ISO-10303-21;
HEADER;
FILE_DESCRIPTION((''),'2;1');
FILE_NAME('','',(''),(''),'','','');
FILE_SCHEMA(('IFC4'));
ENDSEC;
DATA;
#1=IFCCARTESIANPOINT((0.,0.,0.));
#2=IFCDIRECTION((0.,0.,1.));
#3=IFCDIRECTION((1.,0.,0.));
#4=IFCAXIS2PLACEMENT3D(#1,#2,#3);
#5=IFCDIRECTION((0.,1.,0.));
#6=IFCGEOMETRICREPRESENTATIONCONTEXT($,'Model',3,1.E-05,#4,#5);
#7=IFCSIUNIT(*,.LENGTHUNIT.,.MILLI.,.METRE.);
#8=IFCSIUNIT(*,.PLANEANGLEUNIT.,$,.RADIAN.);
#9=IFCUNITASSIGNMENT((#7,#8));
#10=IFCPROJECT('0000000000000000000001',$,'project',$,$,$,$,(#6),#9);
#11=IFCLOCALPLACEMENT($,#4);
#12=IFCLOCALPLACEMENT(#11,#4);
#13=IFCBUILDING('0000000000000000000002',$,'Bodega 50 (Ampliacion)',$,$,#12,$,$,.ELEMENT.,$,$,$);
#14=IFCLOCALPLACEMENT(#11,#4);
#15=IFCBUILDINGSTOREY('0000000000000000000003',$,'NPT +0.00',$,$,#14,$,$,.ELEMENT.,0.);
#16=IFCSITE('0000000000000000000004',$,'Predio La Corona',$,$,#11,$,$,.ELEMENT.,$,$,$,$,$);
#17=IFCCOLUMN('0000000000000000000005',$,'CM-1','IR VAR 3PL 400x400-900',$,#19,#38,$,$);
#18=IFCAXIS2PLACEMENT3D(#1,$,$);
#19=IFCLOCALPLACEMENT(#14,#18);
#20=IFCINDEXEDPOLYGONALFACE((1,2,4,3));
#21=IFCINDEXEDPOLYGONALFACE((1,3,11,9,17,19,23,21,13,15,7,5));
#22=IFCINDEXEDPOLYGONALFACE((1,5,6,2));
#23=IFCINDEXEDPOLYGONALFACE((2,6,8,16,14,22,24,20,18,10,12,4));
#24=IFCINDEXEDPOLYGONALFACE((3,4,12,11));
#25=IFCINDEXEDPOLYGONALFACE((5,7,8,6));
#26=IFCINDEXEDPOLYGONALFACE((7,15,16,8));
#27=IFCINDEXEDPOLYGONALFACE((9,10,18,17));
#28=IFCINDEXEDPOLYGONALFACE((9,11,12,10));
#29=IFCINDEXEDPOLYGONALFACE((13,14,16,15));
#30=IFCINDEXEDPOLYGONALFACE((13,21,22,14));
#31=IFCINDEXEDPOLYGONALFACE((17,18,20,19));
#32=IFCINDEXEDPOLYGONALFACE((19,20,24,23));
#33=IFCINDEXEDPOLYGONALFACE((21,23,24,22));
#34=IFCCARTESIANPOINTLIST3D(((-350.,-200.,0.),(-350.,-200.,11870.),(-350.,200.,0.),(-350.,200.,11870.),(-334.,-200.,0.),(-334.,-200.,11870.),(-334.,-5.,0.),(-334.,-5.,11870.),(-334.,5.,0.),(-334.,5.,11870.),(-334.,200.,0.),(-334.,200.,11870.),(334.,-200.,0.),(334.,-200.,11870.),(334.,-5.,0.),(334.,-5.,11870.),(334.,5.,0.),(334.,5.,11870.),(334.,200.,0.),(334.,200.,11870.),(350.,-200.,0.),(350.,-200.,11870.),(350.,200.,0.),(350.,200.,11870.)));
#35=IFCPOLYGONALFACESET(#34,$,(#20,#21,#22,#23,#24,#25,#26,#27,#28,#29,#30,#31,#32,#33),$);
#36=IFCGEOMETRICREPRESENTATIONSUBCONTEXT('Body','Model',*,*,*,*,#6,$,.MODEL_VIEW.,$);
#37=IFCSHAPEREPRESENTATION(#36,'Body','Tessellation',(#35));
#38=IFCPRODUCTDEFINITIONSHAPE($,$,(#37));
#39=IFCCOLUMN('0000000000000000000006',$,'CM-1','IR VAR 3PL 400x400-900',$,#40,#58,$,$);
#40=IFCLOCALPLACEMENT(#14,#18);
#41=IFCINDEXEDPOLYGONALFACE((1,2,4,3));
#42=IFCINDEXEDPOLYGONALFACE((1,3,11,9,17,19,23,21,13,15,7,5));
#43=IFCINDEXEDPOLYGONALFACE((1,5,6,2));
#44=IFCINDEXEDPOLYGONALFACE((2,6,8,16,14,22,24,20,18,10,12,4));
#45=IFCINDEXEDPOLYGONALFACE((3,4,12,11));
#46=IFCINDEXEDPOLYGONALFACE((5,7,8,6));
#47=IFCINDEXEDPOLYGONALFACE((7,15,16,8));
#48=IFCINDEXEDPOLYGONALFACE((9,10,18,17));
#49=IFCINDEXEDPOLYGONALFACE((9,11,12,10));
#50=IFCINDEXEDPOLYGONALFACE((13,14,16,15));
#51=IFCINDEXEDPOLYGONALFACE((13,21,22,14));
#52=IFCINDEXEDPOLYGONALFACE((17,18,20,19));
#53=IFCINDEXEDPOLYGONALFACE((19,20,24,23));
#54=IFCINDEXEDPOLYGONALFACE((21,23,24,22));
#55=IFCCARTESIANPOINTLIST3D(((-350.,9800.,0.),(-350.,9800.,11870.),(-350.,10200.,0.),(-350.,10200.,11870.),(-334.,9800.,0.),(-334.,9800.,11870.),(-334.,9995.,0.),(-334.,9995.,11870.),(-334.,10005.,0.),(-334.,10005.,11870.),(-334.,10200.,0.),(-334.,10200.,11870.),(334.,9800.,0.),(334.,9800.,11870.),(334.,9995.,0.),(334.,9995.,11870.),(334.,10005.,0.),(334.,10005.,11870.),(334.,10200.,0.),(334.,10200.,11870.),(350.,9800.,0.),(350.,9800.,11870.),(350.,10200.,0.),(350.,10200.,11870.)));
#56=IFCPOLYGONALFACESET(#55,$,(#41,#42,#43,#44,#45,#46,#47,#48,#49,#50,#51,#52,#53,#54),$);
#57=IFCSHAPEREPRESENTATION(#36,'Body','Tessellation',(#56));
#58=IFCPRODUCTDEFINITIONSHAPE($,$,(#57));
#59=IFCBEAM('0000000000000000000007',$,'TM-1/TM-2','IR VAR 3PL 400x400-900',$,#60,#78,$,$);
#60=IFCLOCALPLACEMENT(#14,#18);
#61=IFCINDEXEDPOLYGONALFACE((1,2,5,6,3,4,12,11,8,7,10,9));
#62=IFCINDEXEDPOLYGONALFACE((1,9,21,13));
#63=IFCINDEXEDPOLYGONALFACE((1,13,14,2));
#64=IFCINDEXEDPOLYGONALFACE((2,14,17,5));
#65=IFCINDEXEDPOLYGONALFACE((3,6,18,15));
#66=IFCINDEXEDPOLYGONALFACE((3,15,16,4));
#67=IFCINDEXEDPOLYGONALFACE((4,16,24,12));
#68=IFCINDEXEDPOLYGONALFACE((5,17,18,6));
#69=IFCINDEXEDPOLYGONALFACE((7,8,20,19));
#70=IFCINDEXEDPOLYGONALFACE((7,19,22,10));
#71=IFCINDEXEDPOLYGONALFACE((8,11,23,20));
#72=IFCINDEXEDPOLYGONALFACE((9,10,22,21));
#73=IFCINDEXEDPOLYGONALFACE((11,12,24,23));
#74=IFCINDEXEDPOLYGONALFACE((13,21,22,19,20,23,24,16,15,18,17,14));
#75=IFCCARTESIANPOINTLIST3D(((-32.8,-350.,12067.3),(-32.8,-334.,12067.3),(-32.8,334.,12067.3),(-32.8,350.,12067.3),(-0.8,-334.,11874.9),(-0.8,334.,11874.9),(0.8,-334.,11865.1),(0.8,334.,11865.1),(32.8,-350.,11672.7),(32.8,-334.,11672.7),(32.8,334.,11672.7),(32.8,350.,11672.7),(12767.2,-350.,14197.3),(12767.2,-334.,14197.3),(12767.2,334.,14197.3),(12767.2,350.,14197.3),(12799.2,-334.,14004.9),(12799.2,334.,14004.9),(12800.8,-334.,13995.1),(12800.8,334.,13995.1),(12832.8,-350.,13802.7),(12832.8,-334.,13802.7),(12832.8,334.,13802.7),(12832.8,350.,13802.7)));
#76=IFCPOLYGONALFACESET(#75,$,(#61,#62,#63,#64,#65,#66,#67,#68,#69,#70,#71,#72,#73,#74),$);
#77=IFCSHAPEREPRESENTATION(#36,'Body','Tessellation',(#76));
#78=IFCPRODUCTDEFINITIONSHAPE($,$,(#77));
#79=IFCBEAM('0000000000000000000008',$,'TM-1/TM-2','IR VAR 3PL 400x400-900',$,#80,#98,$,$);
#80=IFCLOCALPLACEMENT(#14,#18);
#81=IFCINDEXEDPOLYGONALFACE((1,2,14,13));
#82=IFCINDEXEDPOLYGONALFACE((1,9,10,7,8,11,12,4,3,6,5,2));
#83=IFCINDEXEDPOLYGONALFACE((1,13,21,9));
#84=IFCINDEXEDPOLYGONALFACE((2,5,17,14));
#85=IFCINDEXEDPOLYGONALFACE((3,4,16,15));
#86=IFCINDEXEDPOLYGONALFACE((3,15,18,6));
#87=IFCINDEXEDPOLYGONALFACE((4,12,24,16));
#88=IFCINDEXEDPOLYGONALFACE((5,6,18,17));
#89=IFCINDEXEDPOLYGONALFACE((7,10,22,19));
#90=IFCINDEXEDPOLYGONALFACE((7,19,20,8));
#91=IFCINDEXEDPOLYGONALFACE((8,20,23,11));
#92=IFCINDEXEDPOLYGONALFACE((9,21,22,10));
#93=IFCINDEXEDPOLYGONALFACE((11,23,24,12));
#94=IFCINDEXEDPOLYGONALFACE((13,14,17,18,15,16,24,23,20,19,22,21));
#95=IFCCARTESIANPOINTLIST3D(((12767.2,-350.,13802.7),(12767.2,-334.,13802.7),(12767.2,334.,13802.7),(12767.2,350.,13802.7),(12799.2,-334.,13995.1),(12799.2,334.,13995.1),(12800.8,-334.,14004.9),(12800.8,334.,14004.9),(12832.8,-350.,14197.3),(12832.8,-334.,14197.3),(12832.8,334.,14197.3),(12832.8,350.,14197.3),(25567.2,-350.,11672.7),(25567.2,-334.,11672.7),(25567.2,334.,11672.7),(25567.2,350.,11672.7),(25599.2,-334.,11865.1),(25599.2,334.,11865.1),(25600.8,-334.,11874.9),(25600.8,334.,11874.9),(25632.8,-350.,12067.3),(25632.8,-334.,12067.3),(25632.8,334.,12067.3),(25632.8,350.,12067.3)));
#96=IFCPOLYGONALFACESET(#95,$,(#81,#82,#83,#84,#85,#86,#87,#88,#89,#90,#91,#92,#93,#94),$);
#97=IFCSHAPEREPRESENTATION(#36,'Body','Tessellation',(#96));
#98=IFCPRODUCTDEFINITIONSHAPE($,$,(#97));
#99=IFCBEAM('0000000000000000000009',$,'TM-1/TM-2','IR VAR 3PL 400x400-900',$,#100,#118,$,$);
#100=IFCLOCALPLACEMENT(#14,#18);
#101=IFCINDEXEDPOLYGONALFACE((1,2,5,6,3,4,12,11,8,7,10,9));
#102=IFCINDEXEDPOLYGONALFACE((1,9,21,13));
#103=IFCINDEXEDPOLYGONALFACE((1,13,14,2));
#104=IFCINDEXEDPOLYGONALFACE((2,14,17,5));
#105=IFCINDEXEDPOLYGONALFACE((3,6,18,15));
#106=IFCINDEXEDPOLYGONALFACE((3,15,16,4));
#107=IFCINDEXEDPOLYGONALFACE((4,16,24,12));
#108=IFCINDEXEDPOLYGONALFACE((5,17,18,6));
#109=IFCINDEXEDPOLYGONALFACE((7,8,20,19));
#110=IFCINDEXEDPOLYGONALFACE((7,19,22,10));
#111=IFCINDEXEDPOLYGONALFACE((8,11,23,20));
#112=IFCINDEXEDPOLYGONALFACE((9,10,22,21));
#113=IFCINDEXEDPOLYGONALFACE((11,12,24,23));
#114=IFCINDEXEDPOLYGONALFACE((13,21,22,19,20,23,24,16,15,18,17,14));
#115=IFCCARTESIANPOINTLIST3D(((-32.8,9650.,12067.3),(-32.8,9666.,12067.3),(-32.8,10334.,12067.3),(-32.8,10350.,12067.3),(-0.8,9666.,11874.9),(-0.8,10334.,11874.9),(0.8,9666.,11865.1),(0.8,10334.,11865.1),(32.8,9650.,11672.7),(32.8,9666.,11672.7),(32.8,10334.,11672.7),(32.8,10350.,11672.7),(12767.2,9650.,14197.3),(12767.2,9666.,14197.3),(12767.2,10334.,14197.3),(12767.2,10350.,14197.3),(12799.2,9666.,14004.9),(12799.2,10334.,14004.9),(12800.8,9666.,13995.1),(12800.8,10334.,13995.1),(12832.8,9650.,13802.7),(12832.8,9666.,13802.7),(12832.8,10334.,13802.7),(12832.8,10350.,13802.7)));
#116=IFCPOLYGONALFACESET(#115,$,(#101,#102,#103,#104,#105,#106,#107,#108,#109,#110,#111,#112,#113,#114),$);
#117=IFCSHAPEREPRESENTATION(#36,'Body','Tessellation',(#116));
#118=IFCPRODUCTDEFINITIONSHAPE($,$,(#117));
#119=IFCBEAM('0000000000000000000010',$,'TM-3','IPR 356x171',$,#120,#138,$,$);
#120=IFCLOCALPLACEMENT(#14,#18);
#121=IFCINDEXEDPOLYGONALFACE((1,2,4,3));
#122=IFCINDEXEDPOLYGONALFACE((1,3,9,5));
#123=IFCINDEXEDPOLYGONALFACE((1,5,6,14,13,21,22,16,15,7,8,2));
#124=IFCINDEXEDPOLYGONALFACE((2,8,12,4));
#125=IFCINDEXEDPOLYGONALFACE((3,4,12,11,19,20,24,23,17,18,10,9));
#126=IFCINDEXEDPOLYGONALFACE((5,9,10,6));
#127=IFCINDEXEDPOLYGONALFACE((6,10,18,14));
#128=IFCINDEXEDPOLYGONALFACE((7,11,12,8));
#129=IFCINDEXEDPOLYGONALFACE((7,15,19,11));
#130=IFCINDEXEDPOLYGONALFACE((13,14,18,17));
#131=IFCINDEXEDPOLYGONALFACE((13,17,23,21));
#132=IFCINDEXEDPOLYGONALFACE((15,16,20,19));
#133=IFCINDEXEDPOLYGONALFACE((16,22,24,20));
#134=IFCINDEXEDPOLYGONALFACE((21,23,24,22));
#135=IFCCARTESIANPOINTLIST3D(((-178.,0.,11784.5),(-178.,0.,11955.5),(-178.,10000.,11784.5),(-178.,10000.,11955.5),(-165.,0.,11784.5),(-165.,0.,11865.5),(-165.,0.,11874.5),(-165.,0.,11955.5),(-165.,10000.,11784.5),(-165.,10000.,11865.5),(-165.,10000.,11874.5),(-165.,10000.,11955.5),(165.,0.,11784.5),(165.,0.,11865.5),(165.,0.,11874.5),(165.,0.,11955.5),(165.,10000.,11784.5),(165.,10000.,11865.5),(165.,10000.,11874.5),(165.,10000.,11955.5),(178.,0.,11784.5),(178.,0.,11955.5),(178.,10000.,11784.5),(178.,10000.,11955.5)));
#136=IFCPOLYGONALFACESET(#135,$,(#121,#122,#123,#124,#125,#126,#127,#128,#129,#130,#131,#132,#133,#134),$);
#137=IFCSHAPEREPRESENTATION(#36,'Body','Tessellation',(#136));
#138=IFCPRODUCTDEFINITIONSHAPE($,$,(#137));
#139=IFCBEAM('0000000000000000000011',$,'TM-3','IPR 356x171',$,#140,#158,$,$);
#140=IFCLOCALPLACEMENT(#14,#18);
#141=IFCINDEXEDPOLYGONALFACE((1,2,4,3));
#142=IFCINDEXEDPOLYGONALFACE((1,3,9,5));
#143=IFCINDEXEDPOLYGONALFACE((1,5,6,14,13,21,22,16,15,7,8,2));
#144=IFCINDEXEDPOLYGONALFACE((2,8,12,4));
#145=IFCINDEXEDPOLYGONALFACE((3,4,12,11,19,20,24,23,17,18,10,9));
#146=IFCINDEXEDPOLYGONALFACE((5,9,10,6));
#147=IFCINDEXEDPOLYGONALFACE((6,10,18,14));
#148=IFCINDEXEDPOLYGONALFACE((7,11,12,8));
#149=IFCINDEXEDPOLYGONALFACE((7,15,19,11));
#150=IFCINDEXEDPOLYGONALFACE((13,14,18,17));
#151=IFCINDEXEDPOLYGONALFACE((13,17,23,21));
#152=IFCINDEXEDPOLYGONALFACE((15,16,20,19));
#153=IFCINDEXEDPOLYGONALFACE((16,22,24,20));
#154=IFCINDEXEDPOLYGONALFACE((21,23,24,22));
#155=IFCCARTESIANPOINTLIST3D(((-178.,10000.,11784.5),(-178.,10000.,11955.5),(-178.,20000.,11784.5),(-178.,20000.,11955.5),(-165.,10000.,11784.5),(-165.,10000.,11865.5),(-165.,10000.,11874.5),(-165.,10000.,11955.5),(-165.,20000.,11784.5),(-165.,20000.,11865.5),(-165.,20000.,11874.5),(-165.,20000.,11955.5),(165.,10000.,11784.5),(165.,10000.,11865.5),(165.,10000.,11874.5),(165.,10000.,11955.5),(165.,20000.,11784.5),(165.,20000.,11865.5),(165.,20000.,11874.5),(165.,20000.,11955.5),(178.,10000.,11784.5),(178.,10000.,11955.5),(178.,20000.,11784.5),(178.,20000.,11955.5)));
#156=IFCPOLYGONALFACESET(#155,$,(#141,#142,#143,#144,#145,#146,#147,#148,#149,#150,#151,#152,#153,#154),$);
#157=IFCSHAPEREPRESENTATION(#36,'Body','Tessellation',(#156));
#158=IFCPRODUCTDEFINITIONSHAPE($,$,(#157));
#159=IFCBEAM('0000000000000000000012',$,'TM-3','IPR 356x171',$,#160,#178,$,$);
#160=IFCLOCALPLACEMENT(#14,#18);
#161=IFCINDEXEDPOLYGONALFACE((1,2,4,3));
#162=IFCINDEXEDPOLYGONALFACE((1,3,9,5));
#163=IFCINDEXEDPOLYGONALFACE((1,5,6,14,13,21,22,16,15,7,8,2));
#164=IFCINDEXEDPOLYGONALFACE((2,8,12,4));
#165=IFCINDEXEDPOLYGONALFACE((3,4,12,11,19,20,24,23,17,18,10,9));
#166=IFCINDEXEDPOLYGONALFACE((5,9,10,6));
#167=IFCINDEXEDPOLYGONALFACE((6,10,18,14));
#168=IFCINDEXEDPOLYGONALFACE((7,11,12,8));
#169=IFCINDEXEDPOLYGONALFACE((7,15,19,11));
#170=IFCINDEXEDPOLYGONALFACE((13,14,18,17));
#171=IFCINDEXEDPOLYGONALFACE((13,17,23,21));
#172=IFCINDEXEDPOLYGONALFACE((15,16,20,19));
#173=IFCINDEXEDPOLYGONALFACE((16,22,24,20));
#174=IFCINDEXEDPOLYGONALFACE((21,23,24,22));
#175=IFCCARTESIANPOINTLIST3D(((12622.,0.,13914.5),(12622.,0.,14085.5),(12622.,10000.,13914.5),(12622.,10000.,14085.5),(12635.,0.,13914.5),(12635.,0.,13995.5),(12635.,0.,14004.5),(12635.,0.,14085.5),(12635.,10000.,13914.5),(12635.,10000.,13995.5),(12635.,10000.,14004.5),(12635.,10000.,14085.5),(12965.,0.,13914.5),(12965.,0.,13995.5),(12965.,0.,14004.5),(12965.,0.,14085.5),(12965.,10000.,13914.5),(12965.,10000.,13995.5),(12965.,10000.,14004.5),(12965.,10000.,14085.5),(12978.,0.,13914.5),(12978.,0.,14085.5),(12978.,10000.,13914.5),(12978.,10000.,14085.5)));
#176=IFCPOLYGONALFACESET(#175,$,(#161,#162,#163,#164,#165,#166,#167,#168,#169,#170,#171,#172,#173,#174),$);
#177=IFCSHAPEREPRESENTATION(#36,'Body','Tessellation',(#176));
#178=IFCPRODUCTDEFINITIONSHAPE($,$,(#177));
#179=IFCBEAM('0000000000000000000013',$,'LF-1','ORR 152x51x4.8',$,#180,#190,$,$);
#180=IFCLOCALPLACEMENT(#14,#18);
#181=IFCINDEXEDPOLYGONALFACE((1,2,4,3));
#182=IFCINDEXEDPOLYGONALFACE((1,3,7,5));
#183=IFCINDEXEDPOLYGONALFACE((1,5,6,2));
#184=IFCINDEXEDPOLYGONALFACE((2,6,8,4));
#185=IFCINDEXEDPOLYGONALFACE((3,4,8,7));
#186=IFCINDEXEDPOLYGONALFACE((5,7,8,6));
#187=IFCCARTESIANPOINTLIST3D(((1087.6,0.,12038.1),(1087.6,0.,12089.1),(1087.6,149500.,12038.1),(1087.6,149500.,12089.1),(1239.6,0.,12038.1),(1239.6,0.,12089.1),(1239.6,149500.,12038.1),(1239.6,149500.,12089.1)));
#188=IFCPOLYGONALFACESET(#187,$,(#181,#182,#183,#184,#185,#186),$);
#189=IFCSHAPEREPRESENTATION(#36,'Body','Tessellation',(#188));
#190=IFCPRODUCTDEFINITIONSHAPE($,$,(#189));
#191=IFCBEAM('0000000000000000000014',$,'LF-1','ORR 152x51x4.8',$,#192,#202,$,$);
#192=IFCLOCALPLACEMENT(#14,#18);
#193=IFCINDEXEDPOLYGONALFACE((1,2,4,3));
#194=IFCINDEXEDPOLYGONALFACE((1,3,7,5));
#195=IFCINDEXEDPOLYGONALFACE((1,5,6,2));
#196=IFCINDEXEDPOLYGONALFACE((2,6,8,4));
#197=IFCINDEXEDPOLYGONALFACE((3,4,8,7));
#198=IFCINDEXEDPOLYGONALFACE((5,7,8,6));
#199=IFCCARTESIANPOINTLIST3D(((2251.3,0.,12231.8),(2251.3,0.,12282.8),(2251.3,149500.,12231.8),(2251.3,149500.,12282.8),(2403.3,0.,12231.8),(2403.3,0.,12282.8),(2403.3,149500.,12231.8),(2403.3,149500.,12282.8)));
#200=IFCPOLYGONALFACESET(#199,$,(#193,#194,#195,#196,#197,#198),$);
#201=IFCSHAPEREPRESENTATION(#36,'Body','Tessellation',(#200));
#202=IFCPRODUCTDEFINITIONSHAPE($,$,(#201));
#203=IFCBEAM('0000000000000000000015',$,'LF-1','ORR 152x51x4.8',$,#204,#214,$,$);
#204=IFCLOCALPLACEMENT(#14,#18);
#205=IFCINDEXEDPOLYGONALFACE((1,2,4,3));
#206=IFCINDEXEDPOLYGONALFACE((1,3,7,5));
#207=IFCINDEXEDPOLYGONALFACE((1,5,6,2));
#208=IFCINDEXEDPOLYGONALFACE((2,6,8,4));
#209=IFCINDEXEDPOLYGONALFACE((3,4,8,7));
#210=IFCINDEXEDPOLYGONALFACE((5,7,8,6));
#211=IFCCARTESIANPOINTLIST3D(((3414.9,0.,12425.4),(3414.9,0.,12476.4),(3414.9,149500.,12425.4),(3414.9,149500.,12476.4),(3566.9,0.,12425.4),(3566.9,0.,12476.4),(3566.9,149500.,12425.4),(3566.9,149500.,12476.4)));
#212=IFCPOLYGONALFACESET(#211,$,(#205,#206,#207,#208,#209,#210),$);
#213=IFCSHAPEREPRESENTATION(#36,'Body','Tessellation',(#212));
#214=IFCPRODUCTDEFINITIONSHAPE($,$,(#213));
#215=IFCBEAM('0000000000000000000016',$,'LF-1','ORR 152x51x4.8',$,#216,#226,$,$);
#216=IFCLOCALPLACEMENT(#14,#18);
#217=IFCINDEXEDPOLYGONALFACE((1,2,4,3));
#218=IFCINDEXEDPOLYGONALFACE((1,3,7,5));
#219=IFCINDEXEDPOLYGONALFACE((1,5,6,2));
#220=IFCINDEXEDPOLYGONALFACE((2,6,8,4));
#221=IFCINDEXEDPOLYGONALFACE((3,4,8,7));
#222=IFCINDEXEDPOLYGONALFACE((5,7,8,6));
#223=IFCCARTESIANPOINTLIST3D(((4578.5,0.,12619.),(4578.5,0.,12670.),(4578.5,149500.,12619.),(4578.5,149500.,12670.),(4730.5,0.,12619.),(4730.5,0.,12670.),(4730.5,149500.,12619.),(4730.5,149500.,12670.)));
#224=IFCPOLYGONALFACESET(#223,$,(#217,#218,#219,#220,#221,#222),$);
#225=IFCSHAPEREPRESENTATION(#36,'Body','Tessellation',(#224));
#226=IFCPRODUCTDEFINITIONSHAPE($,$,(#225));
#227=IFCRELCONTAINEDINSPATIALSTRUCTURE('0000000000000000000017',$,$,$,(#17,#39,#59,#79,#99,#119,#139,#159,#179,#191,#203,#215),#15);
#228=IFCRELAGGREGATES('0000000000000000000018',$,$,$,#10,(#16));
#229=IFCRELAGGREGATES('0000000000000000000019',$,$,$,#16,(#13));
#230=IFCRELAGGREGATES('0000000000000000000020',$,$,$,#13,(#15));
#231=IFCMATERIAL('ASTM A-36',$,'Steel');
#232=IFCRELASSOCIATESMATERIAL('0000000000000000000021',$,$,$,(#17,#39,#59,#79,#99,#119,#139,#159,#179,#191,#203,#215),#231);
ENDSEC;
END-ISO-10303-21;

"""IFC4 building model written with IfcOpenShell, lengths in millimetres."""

from ifc_helpers import new_model, si_unit, direction, frame, origin_with_axes, origin_2d, place, context, subcontext, project, spatial, rectangle, i_section, extrude, material, element, save


model = new_model("IFC4")

# Units and contexts
model_context = context("Model", 3, precision=1e-05, world=origin_with_axes(), true_north=direction((0.0, 1.0, 0.0)))
body_context = subcontext(model_context, "Body", "Model", "MODEL_VIEW")
ifc_project = project(units=[si_unit("LENGTHUNIT", "METRE", prefix="MILLI"), si_unit("PLANEANGLEUNIT", "RADIAN")], contexts=[model_context])

# Site, building, storey
site_placement = place(None, origin_with_axes())
site = spatial("IfcSite", under=ifc_project, at=site_placement, Name="Predio La Corona", CompositionType="ELEMENT")
building_placement = place(site_placement, origin_with_axes())
building = spatial("IfcBuilding", under=site, at=building_placement, Name="Bodega 50 (Ampliacion)", CompositionType="ELEMENT")
storey_placement = place(site_placement, origin_with_axes())
storey = spatial("IfcBuildingStorey", under=building, at=storey_placement, Name="NPT +0.00", CompositionType="ELEMENT", Elevation=0.0)

# Columns
ifc_material = material(Name="ASTM A-36", Category="Steel")
for number, where, z_axis, x_axis, name in (
    (1, (0.0, 0.0, 0.0), (0.0, 0.0, 1.0), (0.0, -1.0, 0.0), "CM-1"),
    (2, (0.0, 10000.0, 0.0), (0.0, 0.0, 1.0), (0.0, -1.0, 0.0), "CM-1"),
):
    element("IfcColumn", number, at=place(storey_placement, frame(where, z_axis=z_axis, x_axis=x_axis)), inside=storey, material=ifc_material, Name=name, Description="IR VAR 3PL 400x400-900", context=body_context, shape_type="SweptSolid", body=[
        extrude(i_section(OverallWidth=400.0, OverallDepth=700.0, WebThickness=10.0, FlangeThickness=16.0, at=origin_2d()), origin_with_axes(), (0.0, 0.0, 1.0), 11870.0),
    ])

# Beams
for number, where, z_axis, x_axis, name in (
    (3, (0.0, 0.0, 11870.0), (0.986436, 0.0, 0.164149), (0.164149, 0.0, -0.986436), "TM-1/TM-2"),
    (4, (12800.0, 0.0, 14000.0), (0.986436, 0.0, -0.164149), (-0.164149, 0.0, -0.986436), "TM-1/TM-2"),
    (5, (0.0, 10000.0, 11870.0), (0.986436, 0.0, 0.164149), (0.164149, 0.0, -0.986436), "TM-1/TM-2"),
):
    element("IfcBeam", number, at=place(storey_placement, frame(where, z_axis=z_axis, x_axis=x_axis)), inside=storey, material=ifc_material, Name=name, Description="IR VAR 3PL 400x400-900", context=body_context, shape_type="SweptSolid", body=[
        extrude(i_section(OverallWidth=400.0, OverallDepth=700.0, WebThickness=10.0, FlangeThickness=16.0, at=origin_2d()), origin_with_axes(), (0.0, 0.0, 1.0), 12976.0),
    ])
for number, where, z_axis, x_axis, name in (
    (6, (0.0, 0.0, 11870.0), (0.0, 1.0, 0.0), (0.0, 0.0, 1.0), "TM-3"),
    (7, (0.0, 10000.0, 11870.0), (0.0, 1.0, 0.0), (0.0, 0.0, 1.0), "TM-3"),
    (8, (12800.0, 0.0, 14000.0), (0.0, 1.0, 0.0), (0.0, 0.0, 1.0), "TM-3"),
):
    element("IfcBeam", number, at=place(storey_placement, frame(where, z_axis=z_axis, x_axis=x_axis)), inside=storey, material=ifc_material, Name=name, Description="IPR 356x171", context=body_context, shape_type="SweptSolid", body=[
        extrude(i_section(OverallWidth=171.0, OverallDepth=356.0, WebThickness=9.0, FlangeThickness=13.0, at=origin_2d()), origin_with_axes(), (0.0, 0.0, 1.0), 10000.0),
    ])
for number, where, z_axis, x_axis, name in (
    (9, (1163.6, 0.0, 12063.6), (0.0, 1.0, 0.0), (0.0, 0.0, 1.0), "LF-1"),
    (10, (2327.3, 0.0, 12257.3), (0.0, 1.0, 0.0), (0.0, 0.0, 1.0), "LF-1"),
    (11, (3490.9, 0.0, 12450.9), (0.0, 1.0, 0.0), (0.0, 0.0, 1.0), "LF-1"),
    (12, (4654.5, 0.0, 12644.5), (0.0, 1.0, 0.0), (0.0, 0.0, 1.0), "LF-1"),
):
    element("IfcBeam", number, at=place(storey_placement, frame(where, z_axis=z_axis, x_axis=x_axis)), inside=storey, material=ifc_material, Name=name, Description="ORR 152x51x4.8", context=body_context, shape_type="SweptSolid", body=[
        extrude(rectangle(XDim=51.0, YDim=152.0, at=origin_2d()), origin_with_axes(), (0.0, 0.0, 1.0), 149500.0),
    ])

save(model, "model.ifc")
